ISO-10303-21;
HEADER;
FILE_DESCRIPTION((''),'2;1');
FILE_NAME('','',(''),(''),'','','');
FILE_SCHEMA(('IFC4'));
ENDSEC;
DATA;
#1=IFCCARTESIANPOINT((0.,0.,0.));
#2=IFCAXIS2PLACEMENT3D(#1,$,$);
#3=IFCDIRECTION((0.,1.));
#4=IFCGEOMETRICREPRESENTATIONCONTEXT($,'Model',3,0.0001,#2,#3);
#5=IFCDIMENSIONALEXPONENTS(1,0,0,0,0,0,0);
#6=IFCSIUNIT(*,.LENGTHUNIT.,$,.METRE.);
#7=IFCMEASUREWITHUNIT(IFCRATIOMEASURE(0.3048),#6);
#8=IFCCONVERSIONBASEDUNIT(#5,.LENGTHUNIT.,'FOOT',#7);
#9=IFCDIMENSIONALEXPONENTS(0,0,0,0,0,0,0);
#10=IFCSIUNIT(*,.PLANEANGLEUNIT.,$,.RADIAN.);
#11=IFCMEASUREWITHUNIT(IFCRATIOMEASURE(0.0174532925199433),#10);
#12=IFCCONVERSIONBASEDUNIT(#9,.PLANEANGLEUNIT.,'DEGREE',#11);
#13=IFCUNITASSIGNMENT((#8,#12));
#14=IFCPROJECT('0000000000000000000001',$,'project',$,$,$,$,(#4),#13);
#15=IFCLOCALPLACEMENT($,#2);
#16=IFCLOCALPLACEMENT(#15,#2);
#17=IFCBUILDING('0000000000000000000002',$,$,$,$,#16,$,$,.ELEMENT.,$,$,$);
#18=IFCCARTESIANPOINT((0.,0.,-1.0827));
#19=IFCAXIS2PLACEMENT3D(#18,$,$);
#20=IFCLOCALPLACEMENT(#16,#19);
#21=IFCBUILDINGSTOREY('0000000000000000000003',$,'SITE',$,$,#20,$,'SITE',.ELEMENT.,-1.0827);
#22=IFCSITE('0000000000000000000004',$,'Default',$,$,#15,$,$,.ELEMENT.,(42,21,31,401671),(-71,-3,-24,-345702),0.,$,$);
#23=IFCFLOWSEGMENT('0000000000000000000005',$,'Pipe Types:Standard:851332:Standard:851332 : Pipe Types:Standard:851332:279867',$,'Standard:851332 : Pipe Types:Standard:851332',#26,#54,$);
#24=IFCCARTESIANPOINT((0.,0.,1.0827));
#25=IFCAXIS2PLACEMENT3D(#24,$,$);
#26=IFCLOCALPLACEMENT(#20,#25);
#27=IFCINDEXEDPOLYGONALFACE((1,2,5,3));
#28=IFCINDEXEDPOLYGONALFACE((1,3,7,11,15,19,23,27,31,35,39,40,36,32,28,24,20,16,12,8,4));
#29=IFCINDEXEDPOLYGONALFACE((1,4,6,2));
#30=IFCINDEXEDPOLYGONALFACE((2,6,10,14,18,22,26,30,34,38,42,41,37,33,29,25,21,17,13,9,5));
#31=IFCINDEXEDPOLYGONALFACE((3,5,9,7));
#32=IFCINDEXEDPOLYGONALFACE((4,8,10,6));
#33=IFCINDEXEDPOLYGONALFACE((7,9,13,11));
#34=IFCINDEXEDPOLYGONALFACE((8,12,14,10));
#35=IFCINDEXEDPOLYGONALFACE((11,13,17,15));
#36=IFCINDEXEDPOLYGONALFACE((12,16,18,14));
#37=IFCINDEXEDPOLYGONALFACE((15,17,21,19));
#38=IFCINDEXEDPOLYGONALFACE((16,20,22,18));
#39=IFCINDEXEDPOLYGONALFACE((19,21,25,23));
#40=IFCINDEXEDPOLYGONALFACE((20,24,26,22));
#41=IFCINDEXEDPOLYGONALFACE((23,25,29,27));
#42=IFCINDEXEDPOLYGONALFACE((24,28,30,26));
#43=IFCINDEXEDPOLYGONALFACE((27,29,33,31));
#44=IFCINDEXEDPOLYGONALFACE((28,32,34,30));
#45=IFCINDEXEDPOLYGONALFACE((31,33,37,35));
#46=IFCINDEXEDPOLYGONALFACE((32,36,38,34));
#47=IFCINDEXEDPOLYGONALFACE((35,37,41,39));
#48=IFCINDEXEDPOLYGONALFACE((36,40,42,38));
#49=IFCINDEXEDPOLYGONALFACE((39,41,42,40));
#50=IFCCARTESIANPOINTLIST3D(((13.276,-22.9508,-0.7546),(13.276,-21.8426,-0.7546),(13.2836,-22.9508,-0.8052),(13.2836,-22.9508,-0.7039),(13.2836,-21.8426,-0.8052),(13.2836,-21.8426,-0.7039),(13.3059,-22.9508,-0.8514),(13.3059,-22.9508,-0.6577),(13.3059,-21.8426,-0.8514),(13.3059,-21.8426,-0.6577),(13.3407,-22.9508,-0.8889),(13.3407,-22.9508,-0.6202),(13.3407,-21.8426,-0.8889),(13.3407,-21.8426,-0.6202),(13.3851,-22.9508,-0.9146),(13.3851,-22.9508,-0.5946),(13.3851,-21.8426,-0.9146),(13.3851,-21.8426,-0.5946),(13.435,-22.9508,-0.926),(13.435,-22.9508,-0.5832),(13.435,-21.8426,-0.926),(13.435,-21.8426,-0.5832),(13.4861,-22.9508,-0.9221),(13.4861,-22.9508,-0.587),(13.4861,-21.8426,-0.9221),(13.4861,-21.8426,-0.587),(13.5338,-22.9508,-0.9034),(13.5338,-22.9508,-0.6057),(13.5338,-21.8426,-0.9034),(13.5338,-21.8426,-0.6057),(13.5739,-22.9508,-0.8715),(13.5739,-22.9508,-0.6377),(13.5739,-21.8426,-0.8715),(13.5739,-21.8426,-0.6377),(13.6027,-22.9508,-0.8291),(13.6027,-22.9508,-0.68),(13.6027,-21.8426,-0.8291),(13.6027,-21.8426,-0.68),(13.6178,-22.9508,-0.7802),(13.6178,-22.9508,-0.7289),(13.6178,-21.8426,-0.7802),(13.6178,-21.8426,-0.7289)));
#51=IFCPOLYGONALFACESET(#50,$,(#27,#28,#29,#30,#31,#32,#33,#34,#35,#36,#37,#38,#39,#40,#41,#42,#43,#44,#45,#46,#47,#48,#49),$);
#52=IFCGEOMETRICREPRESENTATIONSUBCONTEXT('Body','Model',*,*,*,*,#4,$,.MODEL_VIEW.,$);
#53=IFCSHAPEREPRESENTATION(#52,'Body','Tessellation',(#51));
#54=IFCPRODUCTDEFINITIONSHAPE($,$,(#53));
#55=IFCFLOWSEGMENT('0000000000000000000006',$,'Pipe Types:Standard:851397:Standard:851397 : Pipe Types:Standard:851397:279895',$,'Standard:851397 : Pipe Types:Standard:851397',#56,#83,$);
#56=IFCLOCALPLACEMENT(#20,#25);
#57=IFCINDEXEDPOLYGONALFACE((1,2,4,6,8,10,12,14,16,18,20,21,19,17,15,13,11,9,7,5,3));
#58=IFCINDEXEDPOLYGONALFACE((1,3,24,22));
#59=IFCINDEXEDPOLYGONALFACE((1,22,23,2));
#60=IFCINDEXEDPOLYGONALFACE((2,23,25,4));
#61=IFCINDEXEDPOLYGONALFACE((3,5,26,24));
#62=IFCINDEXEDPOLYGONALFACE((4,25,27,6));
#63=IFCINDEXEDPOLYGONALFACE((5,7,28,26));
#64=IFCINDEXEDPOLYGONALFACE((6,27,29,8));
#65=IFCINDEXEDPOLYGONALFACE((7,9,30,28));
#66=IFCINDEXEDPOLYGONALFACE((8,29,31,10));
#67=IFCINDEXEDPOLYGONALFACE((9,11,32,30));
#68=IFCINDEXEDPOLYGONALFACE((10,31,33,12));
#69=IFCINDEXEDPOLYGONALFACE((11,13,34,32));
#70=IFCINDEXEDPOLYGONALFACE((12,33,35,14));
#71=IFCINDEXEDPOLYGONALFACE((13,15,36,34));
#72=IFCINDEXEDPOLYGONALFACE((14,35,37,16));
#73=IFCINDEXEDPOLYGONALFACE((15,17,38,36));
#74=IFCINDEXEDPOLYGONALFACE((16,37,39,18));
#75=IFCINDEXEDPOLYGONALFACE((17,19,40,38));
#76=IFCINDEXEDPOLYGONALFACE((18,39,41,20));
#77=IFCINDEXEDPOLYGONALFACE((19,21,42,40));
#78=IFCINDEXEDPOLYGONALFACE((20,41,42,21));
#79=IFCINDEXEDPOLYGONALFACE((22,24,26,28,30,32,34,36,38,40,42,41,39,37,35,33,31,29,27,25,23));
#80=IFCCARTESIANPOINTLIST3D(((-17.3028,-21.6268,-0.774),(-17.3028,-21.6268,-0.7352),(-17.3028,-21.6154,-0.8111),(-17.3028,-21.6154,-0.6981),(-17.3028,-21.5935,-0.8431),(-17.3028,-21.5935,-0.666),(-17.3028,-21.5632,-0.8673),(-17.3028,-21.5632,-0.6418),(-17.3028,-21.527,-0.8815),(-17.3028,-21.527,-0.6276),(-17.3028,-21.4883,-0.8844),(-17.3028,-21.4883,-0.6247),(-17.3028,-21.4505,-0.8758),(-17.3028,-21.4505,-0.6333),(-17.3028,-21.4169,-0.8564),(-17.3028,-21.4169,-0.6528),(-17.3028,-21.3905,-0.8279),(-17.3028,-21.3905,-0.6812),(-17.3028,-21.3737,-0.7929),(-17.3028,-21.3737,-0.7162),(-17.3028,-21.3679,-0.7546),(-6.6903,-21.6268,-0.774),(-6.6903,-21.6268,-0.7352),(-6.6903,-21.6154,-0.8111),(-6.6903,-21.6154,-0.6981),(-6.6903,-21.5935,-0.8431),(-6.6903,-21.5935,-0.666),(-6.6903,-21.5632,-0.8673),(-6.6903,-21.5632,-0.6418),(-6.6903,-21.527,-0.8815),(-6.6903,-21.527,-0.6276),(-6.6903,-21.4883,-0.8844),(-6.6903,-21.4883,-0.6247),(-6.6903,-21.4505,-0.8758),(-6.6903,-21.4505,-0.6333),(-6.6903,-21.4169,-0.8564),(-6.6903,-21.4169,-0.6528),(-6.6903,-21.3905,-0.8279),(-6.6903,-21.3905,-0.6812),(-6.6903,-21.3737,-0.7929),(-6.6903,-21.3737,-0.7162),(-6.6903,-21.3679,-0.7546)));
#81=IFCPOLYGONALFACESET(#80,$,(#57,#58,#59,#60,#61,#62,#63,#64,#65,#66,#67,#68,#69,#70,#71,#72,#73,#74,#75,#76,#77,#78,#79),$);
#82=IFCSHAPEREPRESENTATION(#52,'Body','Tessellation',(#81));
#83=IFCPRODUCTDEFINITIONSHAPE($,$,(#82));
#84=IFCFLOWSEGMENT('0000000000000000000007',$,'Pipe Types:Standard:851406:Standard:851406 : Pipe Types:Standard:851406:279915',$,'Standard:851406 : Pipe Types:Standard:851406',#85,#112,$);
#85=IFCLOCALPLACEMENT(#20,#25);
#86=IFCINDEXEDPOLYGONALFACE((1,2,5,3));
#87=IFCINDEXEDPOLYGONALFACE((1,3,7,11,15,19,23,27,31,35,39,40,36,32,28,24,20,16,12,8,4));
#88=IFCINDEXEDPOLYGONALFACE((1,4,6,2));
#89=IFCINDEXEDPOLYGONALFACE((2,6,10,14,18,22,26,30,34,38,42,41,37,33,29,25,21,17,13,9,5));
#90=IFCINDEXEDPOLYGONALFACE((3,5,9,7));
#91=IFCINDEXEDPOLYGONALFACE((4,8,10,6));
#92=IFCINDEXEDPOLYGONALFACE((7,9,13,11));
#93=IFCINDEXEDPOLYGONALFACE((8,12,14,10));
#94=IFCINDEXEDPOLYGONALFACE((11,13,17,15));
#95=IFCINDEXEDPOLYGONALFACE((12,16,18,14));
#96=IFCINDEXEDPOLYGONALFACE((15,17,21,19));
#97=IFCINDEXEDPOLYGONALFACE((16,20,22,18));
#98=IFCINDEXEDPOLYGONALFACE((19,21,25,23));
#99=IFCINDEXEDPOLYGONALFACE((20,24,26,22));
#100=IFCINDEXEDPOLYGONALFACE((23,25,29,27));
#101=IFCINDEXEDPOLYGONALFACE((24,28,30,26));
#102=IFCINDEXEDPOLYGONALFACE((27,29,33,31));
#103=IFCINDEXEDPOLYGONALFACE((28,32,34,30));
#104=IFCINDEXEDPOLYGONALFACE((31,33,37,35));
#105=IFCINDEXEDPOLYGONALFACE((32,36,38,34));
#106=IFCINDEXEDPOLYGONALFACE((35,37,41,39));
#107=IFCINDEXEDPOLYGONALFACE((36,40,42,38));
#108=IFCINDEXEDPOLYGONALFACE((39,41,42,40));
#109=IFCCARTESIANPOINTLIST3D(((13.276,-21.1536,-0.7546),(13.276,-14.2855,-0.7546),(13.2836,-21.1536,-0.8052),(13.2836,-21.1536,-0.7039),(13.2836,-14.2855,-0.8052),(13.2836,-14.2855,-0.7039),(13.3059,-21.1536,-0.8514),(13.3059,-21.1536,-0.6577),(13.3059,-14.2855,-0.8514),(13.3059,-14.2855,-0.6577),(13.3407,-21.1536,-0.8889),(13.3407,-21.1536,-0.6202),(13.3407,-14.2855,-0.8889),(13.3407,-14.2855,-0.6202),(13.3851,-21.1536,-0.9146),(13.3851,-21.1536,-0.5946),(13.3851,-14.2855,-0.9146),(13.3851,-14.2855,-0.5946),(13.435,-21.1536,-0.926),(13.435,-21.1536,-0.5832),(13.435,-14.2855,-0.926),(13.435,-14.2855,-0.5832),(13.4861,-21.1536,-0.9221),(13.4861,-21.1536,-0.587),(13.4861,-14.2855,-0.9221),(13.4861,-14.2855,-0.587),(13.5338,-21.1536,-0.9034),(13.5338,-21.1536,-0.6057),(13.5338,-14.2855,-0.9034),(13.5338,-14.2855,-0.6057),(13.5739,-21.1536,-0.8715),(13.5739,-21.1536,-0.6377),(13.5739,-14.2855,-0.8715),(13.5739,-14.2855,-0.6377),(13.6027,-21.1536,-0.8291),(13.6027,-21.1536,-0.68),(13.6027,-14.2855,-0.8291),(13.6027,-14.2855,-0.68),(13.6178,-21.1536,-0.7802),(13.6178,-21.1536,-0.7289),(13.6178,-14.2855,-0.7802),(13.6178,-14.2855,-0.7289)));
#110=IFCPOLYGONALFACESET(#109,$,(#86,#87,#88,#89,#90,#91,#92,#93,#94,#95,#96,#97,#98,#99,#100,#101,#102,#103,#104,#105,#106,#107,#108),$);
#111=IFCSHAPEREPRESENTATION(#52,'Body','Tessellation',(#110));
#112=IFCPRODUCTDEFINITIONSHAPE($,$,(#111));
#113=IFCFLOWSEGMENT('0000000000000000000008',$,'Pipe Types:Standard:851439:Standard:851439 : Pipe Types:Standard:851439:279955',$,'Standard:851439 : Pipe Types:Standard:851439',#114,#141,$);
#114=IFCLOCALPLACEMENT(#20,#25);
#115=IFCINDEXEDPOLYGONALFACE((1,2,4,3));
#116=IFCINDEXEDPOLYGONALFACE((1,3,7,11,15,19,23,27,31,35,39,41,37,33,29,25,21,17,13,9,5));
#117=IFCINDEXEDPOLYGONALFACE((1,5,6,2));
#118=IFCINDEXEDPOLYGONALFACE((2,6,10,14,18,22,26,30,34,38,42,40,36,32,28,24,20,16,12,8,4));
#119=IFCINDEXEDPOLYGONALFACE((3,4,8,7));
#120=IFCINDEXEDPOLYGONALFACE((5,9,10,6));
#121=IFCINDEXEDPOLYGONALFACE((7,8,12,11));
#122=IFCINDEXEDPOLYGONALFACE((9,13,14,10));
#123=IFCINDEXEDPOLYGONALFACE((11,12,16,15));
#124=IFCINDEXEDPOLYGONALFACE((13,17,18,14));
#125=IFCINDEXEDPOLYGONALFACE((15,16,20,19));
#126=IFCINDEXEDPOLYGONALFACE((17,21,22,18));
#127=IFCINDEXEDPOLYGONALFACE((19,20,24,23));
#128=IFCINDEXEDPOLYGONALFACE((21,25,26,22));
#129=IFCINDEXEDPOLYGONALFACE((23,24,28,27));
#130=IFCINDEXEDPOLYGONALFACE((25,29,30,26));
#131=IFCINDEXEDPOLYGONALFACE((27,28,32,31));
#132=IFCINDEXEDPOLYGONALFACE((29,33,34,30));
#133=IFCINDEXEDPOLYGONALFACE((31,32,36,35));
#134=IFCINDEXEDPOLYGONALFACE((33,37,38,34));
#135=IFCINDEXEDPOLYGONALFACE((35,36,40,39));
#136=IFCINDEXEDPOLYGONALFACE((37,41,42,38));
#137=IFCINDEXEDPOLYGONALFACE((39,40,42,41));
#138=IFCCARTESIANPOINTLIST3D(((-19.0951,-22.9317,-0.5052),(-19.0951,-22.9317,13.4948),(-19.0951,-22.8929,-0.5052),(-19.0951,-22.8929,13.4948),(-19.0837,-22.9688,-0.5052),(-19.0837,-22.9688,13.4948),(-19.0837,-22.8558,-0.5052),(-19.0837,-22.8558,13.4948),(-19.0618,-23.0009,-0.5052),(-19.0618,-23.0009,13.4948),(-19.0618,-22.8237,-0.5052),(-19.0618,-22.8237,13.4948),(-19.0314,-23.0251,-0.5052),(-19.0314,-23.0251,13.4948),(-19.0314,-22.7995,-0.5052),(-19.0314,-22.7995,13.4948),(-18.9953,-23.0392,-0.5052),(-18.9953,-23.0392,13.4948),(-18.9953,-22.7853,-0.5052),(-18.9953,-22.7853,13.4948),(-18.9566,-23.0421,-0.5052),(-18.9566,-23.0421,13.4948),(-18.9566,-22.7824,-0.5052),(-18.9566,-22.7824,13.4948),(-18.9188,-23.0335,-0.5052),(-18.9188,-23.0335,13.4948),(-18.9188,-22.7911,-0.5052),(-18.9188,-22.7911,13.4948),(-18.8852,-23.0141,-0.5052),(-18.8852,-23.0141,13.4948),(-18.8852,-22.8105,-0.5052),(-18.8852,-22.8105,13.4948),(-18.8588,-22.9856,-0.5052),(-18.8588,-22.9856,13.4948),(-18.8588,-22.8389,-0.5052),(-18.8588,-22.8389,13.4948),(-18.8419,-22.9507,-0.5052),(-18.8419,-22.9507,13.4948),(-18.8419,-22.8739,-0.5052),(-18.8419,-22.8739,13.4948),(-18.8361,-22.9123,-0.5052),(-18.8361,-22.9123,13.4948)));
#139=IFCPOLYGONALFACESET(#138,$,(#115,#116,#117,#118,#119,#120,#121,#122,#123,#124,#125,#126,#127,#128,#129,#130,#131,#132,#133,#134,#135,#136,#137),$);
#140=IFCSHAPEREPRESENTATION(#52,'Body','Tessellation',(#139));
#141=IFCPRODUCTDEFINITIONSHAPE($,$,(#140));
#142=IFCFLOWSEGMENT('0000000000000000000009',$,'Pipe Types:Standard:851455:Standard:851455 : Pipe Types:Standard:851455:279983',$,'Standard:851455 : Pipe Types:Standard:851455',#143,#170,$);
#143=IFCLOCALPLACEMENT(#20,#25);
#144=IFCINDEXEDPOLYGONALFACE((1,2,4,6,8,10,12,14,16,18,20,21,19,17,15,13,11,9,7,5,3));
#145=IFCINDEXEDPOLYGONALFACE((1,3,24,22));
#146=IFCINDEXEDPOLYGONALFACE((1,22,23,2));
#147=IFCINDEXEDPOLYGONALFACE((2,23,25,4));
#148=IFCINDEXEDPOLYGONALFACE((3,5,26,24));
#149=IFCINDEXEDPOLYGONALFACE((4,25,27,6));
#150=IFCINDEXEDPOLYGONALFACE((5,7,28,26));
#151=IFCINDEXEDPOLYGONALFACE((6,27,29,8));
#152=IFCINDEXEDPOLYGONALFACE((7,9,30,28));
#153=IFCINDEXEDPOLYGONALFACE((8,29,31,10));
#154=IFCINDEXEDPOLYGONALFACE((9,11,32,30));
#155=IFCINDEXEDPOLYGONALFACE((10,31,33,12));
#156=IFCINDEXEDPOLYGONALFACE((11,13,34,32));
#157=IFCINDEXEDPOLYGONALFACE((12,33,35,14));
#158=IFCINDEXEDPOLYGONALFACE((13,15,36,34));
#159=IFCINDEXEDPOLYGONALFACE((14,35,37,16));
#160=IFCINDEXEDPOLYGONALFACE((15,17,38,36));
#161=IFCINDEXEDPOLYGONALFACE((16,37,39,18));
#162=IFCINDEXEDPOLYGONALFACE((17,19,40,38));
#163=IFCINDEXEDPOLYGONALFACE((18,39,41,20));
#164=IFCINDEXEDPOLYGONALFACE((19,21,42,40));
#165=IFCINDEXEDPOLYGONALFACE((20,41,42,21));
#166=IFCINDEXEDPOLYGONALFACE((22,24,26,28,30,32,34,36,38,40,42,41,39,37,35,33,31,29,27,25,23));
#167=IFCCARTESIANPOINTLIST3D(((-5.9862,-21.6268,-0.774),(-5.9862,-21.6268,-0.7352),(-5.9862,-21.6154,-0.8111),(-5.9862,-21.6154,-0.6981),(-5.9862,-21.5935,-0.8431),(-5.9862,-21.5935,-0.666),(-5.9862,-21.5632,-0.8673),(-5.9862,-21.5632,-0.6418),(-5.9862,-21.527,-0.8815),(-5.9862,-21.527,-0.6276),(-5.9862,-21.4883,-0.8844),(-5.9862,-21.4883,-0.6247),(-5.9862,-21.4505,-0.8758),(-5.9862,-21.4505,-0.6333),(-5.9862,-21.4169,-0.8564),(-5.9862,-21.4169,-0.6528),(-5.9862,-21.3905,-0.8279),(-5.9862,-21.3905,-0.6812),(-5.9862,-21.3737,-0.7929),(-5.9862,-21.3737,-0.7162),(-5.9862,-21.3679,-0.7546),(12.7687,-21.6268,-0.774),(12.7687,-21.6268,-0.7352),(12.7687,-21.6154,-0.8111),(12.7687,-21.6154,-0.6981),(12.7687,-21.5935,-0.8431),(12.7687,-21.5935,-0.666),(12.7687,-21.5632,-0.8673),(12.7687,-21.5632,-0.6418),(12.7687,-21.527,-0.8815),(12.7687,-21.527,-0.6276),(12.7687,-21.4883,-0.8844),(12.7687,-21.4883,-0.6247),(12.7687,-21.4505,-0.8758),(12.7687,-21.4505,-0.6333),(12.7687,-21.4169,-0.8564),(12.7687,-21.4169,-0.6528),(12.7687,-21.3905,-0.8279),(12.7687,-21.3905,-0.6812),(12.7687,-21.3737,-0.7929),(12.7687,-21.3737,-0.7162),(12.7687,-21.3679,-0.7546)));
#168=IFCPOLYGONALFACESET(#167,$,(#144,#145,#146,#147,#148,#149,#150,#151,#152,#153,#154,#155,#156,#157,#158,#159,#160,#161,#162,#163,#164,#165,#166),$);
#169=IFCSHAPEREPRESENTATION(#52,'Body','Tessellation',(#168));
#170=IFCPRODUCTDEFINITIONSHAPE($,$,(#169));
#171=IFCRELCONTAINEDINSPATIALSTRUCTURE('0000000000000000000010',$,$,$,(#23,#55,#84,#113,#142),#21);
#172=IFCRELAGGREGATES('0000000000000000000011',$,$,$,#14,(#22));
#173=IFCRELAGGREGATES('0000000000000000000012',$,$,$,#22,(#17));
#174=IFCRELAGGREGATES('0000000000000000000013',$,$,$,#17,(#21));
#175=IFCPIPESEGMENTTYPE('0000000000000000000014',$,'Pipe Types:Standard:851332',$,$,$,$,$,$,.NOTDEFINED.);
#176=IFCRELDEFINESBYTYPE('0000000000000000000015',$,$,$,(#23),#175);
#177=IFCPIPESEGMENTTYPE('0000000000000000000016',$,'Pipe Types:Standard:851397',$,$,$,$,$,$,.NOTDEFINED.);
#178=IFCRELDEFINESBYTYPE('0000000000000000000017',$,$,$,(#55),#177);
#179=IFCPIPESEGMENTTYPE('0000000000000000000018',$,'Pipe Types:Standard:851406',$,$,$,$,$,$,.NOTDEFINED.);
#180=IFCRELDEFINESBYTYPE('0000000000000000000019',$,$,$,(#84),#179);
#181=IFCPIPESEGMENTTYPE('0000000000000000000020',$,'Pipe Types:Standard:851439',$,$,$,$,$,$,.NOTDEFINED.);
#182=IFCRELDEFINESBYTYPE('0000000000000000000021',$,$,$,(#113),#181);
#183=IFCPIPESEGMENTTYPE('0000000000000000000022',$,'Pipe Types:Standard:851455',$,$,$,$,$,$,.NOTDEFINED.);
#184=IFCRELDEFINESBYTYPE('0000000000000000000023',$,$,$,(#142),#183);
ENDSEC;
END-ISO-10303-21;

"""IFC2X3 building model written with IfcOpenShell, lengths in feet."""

from ifc_helpers import new_model, entity, si_unit, converted_unit, direction, frame, frame_2d, origin, origin_2d_with_axis, place, context, subcontext, project, spatial, circle, extrude, source, transform, mapped, type_object, type_shapes, element, save


model = new_model("IFC2X3")

# Units and contexts
model_context = context("Model", 3, precision=0.0001, world=origin(), true_north=direction((0.0, 1.0)))
body_context = subcontext(model_context, "Body", "Model", "MODEL_VIEW")
ifc_project = project(units=[converted_unit("LENGTHUNIT", "FOOT", entity("IfcRatioMeasure", 0.3048), si_unit("LENGTHUNIT", "METRE"), dimensions=[1, 0, 0, 0, 0, 0, 0]), converted_unit("PLANEANGLEUNIT", "DEGREE", entity("IfcRatioMeasure", 0.0174532925199433), si_unit("PLANEANGLEUNIT", "RADIAN"), dimensions=[0, 0, 0, 0, 0, 0, 0])], contexts=[model_context])

# Site, building, storey
site_placement = place(None, origin())
site = spatial("IfcSite", under=ifc_project, at=site_placement, Name="Default", CompositionType="ELEMENT", RefLatitude=(42, 21, 31, 401671), RefLongitude=(-71, -3, -24, -345702), RefElevation=0.0)
building_placement = place(site_placement, origin())
building = spatial("IfcBuilding", under=site, at=building_placement, CompositionType="ELEMENT")
storey_placement = place(building_placement, frame((0.0, 0.0, -1.0827)))
storey = spatial("IfcBuildingStorey", under=building, at=storey_placement, Name="SITE", LongName="SITE", CompositionType="ELEMENT", Elevation=-1.0827)

# Flow segments
pipe_segment_type_1 = type_object("IfcPipeSegmentType", Name="Pipe Types:Standard:851332", PredefinedType="NOTDEFINED")
shared_shape_1 = source(origin(), body_context, "Body", "SweptSolid", [
    extrude(circle(Radius=0.1719, at=frame_2d((0.0, 0.0), x_axis=(1.0, 0.0))), frame((13.4479, -22.9508, -0.7546), z_axis=(0.0, 1.0, 0.0), x_axis=(-1.0, 0.0, 0.0)), (0.0, 0.0, 1.0), 1.1083),
])
type_shapes(pipe_segment_type_1, [shared_shape_1])
flow_segment_1_placement = place(storey_placement, frame((0.0, 0.0, 1.0827)))
element("IfcFlowSegment", 1, at=flow_segment_1_placement, inside=storey, type_object=pipe_segment_type_1, Name="Pipe Types:Standard:851332:Standard:851332 : Pipe Types:Standard:851332:279867", ObjectType="Standard:851332 : Pipe Types:Standard:851332", context=body_context, shape_type="MappedRepresentation", body=[
    mapped(shared_shape_1, transform((0.0, 0.0, 0.0), scale=1.0)),
])
pipe_segment_type_2 = type_object("IfcPipeSegmentType", Name="Pipe Types:Standard:851397", PredefinedType="NOTDEFINED")
shared_shape_2 = source(origin(), body_context, "Body", "SweptSolid", [
    extrude(circle(Radius=0.1302, at=frame_2d((0.0, 0.0), x_axis=(1.0, 0.0))), frame((-17.3028, -21.4981, -0.7546), z_axis=(1.0, 0.0, 0.0), x_axis=(0.0, 1.0, 0.0)), (0.0, 0.0, 1.0), 10.6124),
])
type_shapes(pipe_segment_type_2, [shared_shape_2])
flow_segment_2_placement = place(storey_placement, frame((0.0, 0.0, 1.0827)))
element("IfcFlowSegment", 2, at=flow_segment_2_placement, inside=storey, type_object=pipe_segment_type_2, Name="Pipe Types:Standard:851397:Standard:851397 : Pipe Types:Standard:851397:279895", ObjectType="Standard:851397 : Pipe Types:Standard:851397", context=body_context, shape_type="MappedRepresentation", body=[
    mapped(shared_shape_2, transform((0.0, 0.0, 0.0), scale=1.0)),
])
pipe_segment_type_3 = type_object("IfcPipeSegmentType", Name="Pipe Types:Standard:851406", PredefinedType="NOTDEFINED")
shared_shape_3 = source(origin(), body_context, "Body", "SweptSolid", [
    extrude(circle(Radius=0.1719, at=frame_2d((0.0, 0.0), x_axis=(1.0, 0.0))), frame((13.4479, -21.1536, -0.7546), z_axis=(0.0, 1.0, 0.0), x_axis=(-1.0, 0.0, 0.0)), (0.0, 0.0, 1.0), 6.8681),
])
type_shapes(pipe_segment_type_3, [shared_shape_3])
flow_segment_3_placement = place(storey_placement, frame((0.0, 0.0, 1.0827)))
element("IfcFlowSegment", 3, at=flow_segment_3_placement, inside=storey, type_object=pipe_segment_type_3, Name="Pipe Types:Standard:851406:Standard:851406 : Pipe Types:Standard:851406:279915", ObjectType="Standard:851406 : Pipe Types:Standard:851406", context=body_context, shape_type="MappedRepresentation", body=[
    mapped(shared_shape_3, transform((0.0, 0.0, 0.0), scale=1.0)),
])
pipe_segment_type_4 = type_object("IfcPipeSegmentType", Name="Pipe Types:Standard:851439", PredefinedType="NOTDEFINED")
shared_shape_4 = source(origin(), body_context, "Body", "SweptSolid", [
    extrude(circle(Radius=0.1302, at=origin_2d_with_axis()), frame((-18.9663, -22.9123, -0.5052)), (0.0, 0.0, 1.0), 14.0),
])
type_shapes(pipe_segment_type_4, [shared_shape_4])
flow_segment_4_placement = place(storey_placement, frame((0.0, 0.0, 1.0827)))
element("IfcFlowSegment", 4, at=flow_segment_4_placement, inside=storey, type_object=pipe_segment_type_4, Name="Pipe Types:Standard:851439:Standard:851439 : Pipe Types:Standard:851439:279955", ObjectType="Standard:851439 : Pipe Types:Standard:851439", context=body_context, shape_type="MappedRepresentation", body=[
    mapped(shared_shape_4, transform((0.0, 0.0, 0.0), scale=1.0)),
])
pipe_segment_type_5 = type_object("IfcPipeSegmentType", Name="Pipe Types:Standard:851455", PredefinedType="NOTDEFINED")
shared_shape_5 = source(origin(), body_context, "Body", "SweptSolid", [
    extrude(circle(Radius=0.1302, at=frame_2d((0.0, 0.0), x_axis=(1.0, 0.0))), frame((-5.9862, -21.4981, -0.7546), z_axis=(1.0, 0.0, 0.0), x_axis=(0.0, 1.0, 0.0)), (0.0, 0.0, 1.0), 18.7549),
])
type_shapes(pipe_segment_type_5, [shared_shape_5])
flow_segment_5_placement = place(storey_placement, frame((0.0, 0.0, 1.0827)))
element("IfcFlowSegment", 5, at=flow_segment_5_placement, inside=storey, type_object=pipe_segment_type_5, Name="Pipe Types:Standard:851455:Standard:851455 : Pipe Types:Standard:851455:279983", ObjectType="Standard:851455 : Pipe Types:Standard:851455", context=body_context, shape_type="MappedRepresentation", body=[
    mapped(shared_shape_5, transform((0.0, 0.0, 0.0), scale=1.0)),
])

save(model, "model.ifc")
